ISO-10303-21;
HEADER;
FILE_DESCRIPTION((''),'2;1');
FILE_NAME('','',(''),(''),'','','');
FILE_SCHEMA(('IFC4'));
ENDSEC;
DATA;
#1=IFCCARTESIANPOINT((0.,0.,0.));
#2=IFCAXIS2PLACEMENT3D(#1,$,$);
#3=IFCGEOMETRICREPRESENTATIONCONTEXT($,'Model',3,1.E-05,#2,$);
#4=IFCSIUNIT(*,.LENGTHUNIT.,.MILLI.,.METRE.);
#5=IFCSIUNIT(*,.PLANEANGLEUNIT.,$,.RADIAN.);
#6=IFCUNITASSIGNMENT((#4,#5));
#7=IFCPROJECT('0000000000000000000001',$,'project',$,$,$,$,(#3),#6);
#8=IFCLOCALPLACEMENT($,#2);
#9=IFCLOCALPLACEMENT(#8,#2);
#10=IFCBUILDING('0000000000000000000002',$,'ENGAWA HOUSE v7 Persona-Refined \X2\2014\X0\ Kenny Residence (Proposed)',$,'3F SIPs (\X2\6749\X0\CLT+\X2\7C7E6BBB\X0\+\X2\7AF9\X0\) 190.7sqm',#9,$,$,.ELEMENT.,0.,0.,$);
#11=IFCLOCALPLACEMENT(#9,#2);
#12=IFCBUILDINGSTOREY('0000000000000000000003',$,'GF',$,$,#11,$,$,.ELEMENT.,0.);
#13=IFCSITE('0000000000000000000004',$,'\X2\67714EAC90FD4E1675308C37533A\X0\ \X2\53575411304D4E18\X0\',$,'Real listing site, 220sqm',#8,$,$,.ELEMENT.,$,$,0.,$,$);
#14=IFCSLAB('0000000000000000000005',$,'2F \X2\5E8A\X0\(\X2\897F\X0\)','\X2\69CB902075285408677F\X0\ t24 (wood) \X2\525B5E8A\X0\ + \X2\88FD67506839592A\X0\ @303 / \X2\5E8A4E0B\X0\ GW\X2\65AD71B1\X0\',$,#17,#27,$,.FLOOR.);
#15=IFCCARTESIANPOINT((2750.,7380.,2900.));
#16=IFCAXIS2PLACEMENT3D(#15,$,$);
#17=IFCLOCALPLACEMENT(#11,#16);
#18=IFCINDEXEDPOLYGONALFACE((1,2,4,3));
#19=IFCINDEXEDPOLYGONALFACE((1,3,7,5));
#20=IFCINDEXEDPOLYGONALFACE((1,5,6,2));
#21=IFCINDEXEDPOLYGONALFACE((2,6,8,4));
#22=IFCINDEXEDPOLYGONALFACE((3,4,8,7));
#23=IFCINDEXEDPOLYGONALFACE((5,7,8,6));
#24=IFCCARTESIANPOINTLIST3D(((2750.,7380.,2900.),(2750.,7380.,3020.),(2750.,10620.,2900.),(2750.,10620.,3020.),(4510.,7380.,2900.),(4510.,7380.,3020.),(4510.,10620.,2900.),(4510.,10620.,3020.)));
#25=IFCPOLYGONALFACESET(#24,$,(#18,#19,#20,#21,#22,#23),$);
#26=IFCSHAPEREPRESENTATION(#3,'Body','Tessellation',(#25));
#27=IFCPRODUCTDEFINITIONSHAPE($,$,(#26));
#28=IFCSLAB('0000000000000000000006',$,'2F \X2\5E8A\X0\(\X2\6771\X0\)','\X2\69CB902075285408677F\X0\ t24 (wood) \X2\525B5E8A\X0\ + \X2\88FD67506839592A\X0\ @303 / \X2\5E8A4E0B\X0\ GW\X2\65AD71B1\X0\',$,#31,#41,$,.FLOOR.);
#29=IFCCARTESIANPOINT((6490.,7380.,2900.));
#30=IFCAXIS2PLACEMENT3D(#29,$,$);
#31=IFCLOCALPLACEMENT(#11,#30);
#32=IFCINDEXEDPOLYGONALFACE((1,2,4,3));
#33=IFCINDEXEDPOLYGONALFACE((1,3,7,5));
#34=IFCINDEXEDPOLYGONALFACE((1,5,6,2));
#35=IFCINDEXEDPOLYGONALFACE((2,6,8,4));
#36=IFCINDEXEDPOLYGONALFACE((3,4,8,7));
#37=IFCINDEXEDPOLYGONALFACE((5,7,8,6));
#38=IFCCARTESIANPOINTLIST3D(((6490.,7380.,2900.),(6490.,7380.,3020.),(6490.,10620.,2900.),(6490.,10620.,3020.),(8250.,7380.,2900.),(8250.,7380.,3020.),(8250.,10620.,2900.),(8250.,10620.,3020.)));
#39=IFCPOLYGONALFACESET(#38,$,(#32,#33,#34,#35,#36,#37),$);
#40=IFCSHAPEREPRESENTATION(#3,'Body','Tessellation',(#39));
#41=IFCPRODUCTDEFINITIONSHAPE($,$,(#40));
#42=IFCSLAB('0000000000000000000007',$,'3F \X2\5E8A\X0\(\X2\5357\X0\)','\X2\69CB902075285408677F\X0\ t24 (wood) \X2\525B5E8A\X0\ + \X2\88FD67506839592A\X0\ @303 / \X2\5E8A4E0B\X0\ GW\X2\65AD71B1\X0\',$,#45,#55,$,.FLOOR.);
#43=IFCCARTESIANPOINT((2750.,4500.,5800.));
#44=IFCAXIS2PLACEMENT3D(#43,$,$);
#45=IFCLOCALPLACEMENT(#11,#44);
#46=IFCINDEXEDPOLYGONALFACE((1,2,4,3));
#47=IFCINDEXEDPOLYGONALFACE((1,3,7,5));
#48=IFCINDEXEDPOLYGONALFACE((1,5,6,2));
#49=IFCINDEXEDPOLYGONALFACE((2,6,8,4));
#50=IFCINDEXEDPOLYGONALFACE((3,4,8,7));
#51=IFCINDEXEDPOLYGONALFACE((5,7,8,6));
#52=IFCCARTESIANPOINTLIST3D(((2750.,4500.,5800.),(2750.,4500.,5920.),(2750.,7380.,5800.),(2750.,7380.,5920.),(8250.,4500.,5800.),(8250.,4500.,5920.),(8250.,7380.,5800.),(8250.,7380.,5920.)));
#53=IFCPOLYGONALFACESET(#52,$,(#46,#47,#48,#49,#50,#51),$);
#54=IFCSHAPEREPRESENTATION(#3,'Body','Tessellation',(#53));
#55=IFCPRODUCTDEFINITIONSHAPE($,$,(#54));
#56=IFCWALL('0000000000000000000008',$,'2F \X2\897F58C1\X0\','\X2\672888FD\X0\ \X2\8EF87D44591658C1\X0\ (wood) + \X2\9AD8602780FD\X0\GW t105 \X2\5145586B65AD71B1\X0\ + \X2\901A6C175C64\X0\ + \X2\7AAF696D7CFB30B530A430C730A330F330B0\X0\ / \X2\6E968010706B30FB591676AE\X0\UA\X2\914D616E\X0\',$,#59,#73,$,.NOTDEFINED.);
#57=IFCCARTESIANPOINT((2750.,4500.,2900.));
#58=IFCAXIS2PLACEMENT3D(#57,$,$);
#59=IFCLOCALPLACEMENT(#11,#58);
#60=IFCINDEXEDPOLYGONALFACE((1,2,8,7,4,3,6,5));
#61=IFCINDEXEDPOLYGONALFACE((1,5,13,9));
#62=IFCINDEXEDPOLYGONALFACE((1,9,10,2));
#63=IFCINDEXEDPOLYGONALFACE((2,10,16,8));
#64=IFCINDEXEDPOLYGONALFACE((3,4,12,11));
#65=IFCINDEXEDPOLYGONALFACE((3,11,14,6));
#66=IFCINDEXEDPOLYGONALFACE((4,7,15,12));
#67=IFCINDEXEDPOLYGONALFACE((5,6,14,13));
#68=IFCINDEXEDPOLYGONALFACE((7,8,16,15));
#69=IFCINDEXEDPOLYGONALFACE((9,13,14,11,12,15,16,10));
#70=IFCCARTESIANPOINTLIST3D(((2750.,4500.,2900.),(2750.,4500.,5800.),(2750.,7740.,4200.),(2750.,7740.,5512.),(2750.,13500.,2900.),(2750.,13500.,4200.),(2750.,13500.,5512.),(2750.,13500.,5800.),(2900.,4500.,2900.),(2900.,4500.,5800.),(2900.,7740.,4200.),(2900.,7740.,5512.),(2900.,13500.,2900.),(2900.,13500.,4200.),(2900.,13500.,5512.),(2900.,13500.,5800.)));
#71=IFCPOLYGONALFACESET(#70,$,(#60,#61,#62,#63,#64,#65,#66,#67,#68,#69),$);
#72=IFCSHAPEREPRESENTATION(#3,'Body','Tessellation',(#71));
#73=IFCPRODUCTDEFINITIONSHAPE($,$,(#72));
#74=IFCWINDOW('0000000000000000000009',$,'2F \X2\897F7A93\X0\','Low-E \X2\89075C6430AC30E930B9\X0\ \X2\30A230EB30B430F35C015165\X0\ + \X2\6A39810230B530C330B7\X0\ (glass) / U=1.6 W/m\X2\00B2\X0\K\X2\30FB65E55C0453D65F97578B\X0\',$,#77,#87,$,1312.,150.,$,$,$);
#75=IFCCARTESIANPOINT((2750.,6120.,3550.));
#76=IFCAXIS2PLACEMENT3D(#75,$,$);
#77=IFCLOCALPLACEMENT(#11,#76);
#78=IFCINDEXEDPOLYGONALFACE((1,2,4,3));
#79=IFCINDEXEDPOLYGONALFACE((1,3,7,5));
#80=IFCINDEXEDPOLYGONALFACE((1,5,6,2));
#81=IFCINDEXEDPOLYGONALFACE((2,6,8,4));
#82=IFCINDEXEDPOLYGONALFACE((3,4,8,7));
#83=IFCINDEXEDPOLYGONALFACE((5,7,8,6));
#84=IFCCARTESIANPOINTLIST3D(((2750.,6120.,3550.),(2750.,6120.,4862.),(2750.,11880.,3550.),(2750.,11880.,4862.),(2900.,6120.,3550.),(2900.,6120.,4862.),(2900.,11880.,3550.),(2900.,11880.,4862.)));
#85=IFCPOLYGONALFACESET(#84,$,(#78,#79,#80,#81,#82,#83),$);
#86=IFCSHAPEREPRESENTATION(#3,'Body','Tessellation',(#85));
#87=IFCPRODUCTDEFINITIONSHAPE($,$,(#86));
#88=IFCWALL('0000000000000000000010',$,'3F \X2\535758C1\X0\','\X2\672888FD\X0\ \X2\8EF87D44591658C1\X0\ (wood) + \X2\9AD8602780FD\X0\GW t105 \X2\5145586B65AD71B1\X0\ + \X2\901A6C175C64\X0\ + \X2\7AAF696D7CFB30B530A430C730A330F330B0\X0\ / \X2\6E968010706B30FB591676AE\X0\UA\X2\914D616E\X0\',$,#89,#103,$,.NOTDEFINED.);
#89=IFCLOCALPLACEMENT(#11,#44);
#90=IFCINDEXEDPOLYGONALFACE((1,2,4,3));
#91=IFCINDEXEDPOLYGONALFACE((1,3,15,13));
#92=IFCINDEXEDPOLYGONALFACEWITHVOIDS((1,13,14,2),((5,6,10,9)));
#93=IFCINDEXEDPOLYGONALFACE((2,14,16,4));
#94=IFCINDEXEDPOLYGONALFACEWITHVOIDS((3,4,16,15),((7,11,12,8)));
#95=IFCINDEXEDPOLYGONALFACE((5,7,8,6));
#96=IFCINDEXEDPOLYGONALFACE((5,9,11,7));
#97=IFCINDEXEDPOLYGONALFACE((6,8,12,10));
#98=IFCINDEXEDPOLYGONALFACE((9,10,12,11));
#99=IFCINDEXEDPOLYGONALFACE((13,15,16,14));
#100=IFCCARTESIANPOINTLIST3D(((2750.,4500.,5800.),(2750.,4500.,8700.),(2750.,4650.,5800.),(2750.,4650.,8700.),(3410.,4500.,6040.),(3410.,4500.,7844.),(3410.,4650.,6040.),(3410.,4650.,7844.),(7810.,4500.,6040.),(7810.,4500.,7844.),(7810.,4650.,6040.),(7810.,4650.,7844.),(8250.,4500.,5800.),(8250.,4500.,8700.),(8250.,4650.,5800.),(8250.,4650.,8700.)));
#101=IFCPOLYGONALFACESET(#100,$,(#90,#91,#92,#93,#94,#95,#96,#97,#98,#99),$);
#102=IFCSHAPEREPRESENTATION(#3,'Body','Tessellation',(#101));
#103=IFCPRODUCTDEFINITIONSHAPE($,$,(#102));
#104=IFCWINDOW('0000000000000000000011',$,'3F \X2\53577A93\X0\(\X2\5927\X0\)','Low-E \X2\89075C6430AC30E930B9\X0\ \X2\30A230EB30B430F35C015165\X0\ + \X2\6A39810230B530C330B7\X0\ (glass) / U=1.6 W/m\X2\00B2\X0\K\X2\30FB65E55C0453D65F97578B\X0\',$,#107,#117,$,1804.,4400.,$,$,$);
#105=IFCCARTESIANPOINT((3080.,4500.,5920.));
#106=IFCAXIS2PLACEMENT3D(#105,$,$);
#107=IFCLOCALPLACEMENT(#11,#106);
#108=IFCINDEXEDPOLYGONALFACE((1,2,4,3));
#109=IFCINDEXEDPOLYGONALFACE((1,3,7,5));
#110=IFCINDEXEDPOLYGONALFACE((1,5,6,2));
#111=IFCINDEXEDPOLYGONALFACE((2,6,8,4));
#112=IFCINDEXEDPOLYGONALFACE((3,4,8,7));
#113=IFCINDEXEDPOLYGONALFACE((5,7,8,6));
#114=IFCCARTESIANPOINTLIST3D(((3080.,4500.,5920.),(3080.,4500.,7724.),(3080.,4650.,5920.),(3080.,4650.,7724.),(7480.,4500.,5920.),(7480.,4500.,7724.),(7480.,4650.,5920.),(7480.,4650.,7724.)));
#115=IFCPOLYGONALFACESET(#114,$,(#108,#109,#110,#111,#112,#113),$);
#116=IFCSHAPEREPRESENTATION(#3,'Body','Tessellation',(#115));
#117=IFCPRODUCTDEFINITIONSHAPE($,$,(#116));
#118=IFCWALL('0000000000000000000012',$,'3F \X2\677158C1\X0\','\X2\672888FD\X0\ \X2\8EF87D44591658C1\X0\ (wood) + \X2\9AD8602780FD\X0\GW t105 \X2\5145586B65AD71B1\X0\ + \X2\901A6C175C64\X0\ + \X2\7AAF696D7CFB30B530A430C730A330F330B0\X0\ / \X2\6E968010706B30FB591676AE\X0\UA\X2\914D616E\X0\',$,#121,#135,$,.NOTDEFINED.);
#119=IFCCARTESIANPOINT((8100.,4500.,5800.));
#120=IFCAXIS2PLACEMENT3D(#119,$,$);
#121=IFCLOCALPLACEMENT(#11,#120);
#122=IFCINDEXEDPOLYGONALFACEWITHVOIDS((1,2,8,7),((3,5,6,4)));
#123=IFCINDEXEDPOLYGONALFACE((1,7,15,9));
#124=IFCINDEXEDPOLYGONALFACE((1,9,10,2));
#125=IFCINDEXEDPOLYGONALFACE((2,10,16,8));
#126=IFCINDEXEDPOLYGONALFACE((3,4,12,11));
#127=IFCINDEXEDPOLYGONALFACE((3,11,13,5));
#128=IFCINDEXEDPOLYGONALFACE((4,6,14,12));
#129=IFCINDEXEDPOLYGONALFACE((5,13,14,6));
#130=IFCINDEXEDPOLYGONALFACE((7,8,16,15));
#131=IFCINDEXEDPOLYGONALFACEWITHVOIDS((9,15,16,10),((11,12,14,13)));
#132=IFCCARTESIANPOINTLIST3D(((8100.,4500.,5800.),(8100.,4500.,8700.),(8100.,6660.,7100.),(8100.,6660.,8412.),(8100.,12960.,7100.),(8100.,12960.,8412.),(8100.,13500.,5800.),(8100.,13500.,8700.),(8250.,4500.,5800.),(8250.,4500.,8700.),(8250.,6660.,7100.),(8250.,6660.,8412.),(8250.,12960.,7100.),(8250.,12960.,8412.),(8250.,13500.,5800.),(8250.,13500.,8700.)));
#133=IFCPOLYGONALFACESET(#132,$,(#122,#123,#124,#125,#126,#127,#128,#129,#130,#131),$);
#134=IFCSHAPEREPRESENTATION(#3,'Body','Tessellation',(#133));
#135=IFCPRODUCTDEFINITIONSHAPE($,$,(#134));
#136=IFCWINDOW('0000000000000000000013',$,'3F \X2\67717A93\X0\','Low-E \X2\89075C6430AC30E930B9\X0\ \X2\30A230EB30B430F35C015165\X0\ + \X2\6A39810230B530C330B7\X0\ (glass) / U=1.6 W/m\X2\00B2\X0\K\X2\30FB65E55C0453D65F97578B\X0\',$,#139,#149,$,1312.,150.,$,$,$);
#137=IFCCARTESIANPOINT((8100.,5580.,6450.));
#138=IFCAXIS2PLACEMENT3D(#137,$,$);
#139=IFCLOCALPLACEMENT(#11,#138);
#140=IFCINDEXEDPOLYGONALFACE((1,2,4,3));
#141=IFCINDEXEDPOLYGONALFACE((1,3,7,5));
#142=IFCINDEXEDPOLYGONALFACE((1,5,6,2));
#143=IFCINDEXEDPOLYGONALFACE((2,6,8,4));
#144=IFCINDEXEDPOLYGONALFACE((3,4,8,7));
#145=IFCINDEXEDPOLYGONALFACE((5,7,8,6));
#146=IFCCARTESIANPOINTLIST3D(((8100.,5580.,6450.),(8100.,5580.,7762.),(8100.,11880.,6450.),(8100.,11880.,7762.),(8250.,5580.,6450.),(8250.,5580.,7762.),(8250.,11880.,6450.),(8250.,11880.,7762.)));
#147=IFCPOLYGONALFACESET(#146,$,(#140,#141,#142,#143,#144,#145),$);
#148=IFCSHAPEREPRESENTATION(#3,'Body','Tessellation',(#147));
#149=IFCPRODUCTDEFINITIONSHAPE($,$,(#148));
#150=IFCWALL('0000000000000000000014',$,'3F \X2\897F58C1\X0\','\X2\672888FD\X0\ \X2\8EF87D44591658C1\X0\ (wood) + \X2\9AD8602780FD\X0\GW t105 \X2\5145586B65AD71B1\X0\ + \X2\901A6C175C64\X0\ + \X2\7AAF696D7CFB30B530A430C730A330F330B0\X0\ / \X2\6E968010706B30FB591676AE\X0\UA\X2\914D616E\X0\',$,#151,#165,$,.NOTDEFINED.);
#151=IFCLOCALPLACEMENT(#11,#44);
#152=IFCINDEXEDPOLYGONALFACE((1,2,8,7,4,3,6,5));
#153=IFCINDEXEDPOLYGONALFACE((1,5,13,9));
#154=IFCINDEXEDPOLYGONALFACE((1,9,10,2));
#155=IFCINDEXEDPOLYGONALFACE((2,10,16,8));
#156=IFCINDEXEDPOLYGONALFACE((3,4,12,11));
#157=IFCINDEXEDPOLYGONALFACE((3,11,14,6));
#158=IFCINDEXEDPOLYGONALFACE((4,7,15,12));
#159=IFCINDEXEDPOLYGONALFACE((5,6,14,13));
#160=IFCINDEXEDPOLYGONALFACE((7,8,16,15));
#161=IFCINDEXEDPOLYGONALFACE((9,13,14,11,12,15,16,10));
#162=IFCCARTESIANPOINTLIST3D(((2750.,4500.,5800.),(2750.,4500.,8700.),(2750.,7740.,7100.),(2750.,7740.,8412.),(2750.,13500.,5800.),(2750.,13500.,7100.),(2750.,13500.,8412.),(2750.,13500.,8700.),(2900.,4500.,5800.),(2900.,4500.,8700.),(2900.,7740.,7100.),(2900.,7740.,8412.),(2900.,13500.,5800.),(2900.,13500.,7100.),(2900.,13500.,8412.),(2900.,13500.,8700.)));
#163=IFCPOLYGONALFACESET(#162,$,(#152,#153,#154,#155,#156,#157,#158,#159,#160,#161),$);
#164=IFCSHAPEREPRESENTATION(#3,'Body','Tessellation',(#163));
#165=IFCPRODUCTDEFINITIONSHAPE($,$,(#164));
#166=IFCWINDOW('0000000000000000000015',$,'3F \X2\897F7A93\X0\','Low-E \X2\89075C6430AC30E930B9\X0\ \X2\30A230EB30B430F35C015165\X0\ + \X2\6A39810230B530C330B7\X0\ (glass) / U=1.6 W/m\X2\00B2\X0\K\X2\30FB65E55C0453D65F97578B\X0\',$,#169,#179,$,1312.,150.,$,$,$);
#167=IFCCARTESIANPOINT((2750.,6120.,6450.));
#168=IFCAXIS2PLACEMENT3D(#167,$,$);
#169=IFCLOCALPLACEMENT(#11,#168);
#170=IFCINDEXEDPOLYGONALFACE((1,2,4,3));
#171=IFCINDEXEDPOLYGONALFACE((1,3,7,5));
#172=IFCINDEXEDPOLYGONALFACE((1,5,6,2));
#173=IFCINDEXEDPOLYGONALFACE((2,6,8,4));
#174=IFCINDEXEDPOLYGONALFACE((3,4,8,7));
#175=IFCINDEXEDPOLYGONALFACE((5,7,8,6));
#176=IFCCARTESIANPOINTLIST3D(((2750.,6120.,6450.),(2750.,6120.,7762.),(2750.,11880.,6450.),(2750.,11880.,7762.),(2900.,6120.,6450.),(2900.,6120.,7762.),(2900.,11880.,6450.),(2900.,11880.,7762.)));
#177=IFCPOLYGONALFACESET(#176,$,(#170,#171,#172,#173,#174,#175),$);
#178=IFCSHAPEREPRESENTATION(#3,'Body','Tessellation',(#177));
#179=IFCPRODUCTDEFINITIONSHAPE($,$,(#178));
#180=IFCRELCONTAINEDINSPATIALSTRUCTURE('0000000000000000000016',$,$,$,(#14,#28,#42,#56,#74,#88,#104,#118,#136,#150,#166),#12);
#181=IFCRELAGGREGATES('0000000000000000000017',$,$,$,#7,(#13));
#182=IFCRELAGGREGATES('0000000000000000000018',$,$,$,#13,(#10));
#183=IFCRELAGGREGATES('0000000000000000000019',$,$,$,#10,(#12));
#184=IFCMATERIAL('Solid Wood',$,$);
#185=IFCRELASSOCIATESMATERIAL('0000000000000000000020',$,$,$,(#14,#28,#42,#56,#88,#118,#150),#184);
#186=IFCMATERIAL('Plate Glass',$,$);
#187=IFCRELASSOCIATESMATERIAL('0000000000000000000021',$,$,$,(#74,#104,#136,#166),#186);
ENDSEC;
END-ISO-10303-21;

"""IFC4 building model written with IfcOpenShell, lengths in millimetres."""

from ifc_helpers import new_model, si_unit, frame, frame_2d, origin, place, context, project, spatial, rectangle, extrude, material, element, fill, save


model = new_model("IFC4")

# Units and contexts
model_context = context("Model", 3, precision=1e-05, world=origin())
ifc_project = project(units=[si_unit("LENGTHUNIT", "METRE", prefix="MILLI"), si_unit("PLANEANGLEUNIT", "RADIAN")], contexts=[model_context])

# Site, building, storey
site_placement = place(None, origin())
site = spatial("IfcSite", under=ifc_project, at=site_placement, Name="東京都世田谷区 南向き丘", ObjectType="Real listing site, 220sqm", CompositionType="ELEMENT", RefElevation=0.0)
building_placement = place(site_placement, origin())
building = spatial("IfcBuilding", under=site, at=building_placement, Name="ENGAWA HOUSE v7 Persona-Refined — Kenny Residence (Proposed)", ObjectType="3F SIPs (杉CLT+籾殻+竹) 190.7sqm", CompositionType="ELEMENT", ElevationOfRefHeight=0.0, ElevationOfTerrain=0.0)
storey_placement = place(building_placement, origin())
storey = spatial("IfcBuildingStorey", under=building, at=storey_placement, Name="GF", CompositionType="ELEMENT", Elevation=0.0)

# Slabs
ifc_material_1 = material(Name="Solid Wood")
slab_1_placement = place(storey_placement, frame((2750.0, 7380.0, 2900.0)))
element("IfcSlab", 1, at=slab_1_placement, inside=storey, material=ifc_material_1, Name="2F 床(西)", Description="構造用合板 t24 (wood) 剛床 + 製材根太 @303 / 床下 GW断熱", PredefinedType="FLOOR", context=model_context, shape_type="SweptSolid", body=[
    extrude(rectangle(XDim=1760.0, YDim=3240.0, at=frame_2d((880.0, 1620.0))), frame((2750.0, 7380.0, 2900.0)), (0.0, 0.0, 1.0), 120.0),
])
slab_2_placement = place(storey_placement, frame((6490.0, 7380.0, 2900.0)))
element("IfcSlab", 2, at=slab_2_placement, inside=storey, material=ifc_material_1, Name="2F 床(東)", Description="構造用合板 t24 (wood) 剛床 + 製材根太 @303 / 床下 GW断熱", PredefinedType="FLOOR", context=model_context, shape_type="SweptSolid", body=[
    extrude(rectangle(XDim=1760.0, YDim=3240.0, at=frame_2d((880.0, 1620.0))), frame((6490.0, 7380.0, 2900.0)), (0.0, 0.0, 1.0), 120.0),
])
slab_3_placement = place(storey_placement, frame((2750.0, 4500.0, 5800.0)))
element("IfcSlab", 3, at=slab_3_placement, inside=storey, material=ifc_material_1, Name="3F 床(南)", Description="構造用合板 t24 (wood) 剛床 + 製材根太 @303 / 床下 GW断熱", PredefinedType="FLOOR", context=model_context, shape_type="SweptSolid", body=[
    extrude(rectangle(XDim=5500.0, YDim=2880.0, at=frame_2d((2750.0, 1440.0))), frame((2750.0, 4500.0, 5800.0)), (0.0, 0.0, 1.0), 120.0),
])

# Walls, openings, windows
wall_1_placement = place(storey_placement, frame((2750.0, 4500.0, 2900.0)))
wall_1 = element("IfcWall", 4, at=wall_1_placement, inside=storey, material=ifc_material_1, Name="2F 西壁", Description="木製 軸組外壁 (wood) + 高性能GW t105 充填断熱 + 通気層 + 窯業系サイディング / 準耐火・外皮UA配慮", PredefinedType="NOTDEFINED", context=model_context, shape_type="SweptSolid", body=[
    extrude(rectangle(XDim=150.0, YDim=9000.0, at=frame_2d((75.0, 4500.0))), frame((2750.0, 4500.0, 2900.0)), (0.0, 0.0, 1.0), 2900.0),
])
opening_1_placement = place(storey_placement, frame((2750.0, 6120.0, 3550.0)))
opening_1 = element("IfcOpeningElement", 5, at=opening_1_placement, cuts=wall_1, PredefinedType="NOTDEFINED", context=model_context, shape_type="SweptSolid", body=[
    extrude(rectangle(XDim=150.0, YDim=5760.0, at=frame_2d((75.0, 2880.0))), frame((2750.0, 6120.0, 3550.0)), (0.0, 0.0, 1.0), 1312.0),
])
ifc_material_2 = material(Name="Plate Glass")
window_1_placement = place(storey_placement, frame((2750.0, 6120.0, 3550.0)))
window_1 = element("IfcWindow", 6, at=window_1_placement, inside=storey, material=ifc_material_2, Name="2F 西窓", Description="Low-E 複層ガラス アルゴン封入 + 樹脂サッシ (glass) / U=1.6 W/m²K・日射取得型", OverallHeight=1312.0, OverallWidth=150.0, context=model_context, shape_type="SweptSolid", body=[
    extrude(rectangle(XDim=150.0, YDim=5760.0, at=frame_2d((75.0, 2880.0))), frame((2750.0, 6120.0, 3550.0)), (0.0, 0.0, 1.0), 1312.0),
])
fill(opening_1, window_1)
wall_2_placement = place(storey_placement, frame((2750.0, 4500.0, 5800.0)))
wall_2 = element("IfcWall", 7, at=wall_2_placement, inside=storey, material=ifc_material_1, Name="3F 南壁", Description="木製 軸組外壁 (wood) + 高性能GW t105 充填断熱 + 通気層 + 窯業系サイディング / 準耐火・外皮UA配慮", PredefinedType="NOTDEFINED", context=model_context, shape_type="SweptSolid", body=[
    extrude(rectangle(XDim=5500.0, YDim=150.0, at=frame_2d((2750.0, 75.0))), frame((2750.0, 4500.0, 5800.0)), (0.0, 0.0, 1.0), 2900.0),
])
opening_2_placement = place(storey_placement, frame((3080.0, 4500.0, 5920.0)))
opening_2 = element("IfcOpeningElement", 8, at=opening_2_placement, cuts=wall_2, PredefinedType="NOTDEFINED", context=model_context, shape_type="SweptSolid", body=[
    extrude(rectangle(XDim=4400.0, YDim=150.0, at=frame_2d((2200.0, 75.0))), frame((3080.0, 4500.0, 5920.0)), (0.0, 0.0, 1.0), 1804.0),
])
window_2_placement = place(storey_placement, frame((3080.0, 4500.0, 5920.0)))
window_2 = element("IfcWindow", 9, at=window_2_placement, inside=storey, material=ifc_material_2, Name="3F 南窓(大)", Description="Low-E 複層ガラス アルゴン封入 + 樹脂サッシ (glass) / U=1.6 W/m²K・日射取得型", OverallHeight=1804.0, OverallWidth=4400.0, context=model_context, shape_type="SweptSolid", body=[
    extrude(rectangle(XDim=4400.0, YDim=150.0, at=frame_2d((2200.0, 75.0))), frame((3080.0, 4500.0, 5920.0)), (0.0, 0.0, 1.0), 1804.0),
])
fill(opening_2, window_2)
wall_3_placement = place(storey_placement, frame((8100.0, 4500.0, 5800.0)))
wall_3 = element("IfcWall", 10, at=wall_3_placement, inside=storey, material=ifc_material_1, Name="3F 東壁", Description="木製 軸組外壁 (wood) + 高性能GW t105 充填断熱 + 通気層 + 窯業系サイディング / 準耐火・外皮UA配慮", PredefinedType="NOTDEFINED", context=model_context, shape_type="SweptSolid", body=[
    extrude(rectangle(XDim=150.0, YDim=9000.0, at=frame_2d((75.0, 4500.0))), frame((8100.0, 4500.0, 5800.0)), (0.0, 0.0, 1.0), 2900.0),
])
opening_3_placement = place(storey_placement, frame((8100.0, 5580.0, 6450.0)))
opening_3 = element("IfcOpeningElement", 11, at=opening_3_placement, cuts=wall_3, PredefinedType="NOTDEFINED", context=model_context, shape_type="SweptSolid", body=[
    extrude(rectangle(XDim=150.0, YDim=6300.0, at=frame_2d((75.0, 3150.0))), frame((8100.0, 5580.0, 6450.0)), (0.0, 0.0, 1.0), 1312.0),
])
window_3_placement = place(storey_placement, frame((8100.0, 5580.0, 6450.0)))
window_3 = element("IfcWindow", 12, at=window_3_placement, inside=storey, material=ifc_material_2, Name="3F 東窓", Description="Low-E 複層ガラス アルゴン封入 + 樹脂サッシ (glass) / U=1.6 W/m²K・日射取得型", OverallHeight=1312.0, OverallWidth=150.0, context=model_context, shape_type="SweptSolid", body=[
    extrude(rectangle(XDim=150.0, YDim=6300.0, at=frame_2d((75.0, 3150.0))), frame((8100.0, 5580.0, 6450.0)), (0.0, 0.0, 1.0), 1312.0),
])
fill(opening_3, window_3)
wall_4_placement = place(storey_placement, frame((2750.0, 4500.0, 5800.0)))
wall_4 = element("IfcWall", 13, at=wall_4_placement, inside=storey, material=ifc_material_1, Name="3F 西壁", Description="木製 軸組外壁 (wood) + 高性能GW t105 充填断熱 + 通気層 + 窯業系サイディング / 準耐火・外皮UA配慮", PredefinedType="NOTDEFINED", context=model_context, shape_type="SweptSolid", body=[
    extrude(rectangle(XDim=150.0, YDim=9000.0, at=frame_2d((75.0, 4500.0))), frame((2750.0, 4500.0, 5800.0)), (0.0, 0.0, 1.0), 2900.0),
])
opening_4_placement = place(storey_placement, frame((2750.0, 6120.0, 6450.0)))
opening_4 = element("IfcOpeningElement", 14, at=opening_4_placement, cuts=wall_4, PredefinedType="NOTDEFINED", context=model_context, shape_type="SweptSolid", body=[
    extrude(rectangle(XDim=150.0, YDim=5760.0, at=frame_2d((75.0, 2880.0))), frame((2750.0, 6120.0, 6450.0)), (0.0, 0.0, 1.0), 1312.0),
])
window_4_placement = place(storey_placement, frame((2750.0, 6120.0, 6450.0)))
window_4 = element("IfcWindow", 15, at=window_4_placement, inside=storey, material=ifc_material_2, Name="3F 西窓", Description="Low-E 複層ガラス アルゴン封入 + 樹脂サッシ (glass) / U=1.6 W/m²K・日射取得型", OverallHeight=1312.0, OverallWidth=150.0, context=model_context, shape_type="SweptSolid", body=[
    extrude(rectangle(XDim=150.0, YDim=5760.0, at=frame_2d((75.0, 2880.0))), frame((2750.0, 6120.0, 6450.0)), (0.0, 0.0, 1.0), 1312.0),
])
fill(opening_4, window_4)

save(model, "model.ifc")
